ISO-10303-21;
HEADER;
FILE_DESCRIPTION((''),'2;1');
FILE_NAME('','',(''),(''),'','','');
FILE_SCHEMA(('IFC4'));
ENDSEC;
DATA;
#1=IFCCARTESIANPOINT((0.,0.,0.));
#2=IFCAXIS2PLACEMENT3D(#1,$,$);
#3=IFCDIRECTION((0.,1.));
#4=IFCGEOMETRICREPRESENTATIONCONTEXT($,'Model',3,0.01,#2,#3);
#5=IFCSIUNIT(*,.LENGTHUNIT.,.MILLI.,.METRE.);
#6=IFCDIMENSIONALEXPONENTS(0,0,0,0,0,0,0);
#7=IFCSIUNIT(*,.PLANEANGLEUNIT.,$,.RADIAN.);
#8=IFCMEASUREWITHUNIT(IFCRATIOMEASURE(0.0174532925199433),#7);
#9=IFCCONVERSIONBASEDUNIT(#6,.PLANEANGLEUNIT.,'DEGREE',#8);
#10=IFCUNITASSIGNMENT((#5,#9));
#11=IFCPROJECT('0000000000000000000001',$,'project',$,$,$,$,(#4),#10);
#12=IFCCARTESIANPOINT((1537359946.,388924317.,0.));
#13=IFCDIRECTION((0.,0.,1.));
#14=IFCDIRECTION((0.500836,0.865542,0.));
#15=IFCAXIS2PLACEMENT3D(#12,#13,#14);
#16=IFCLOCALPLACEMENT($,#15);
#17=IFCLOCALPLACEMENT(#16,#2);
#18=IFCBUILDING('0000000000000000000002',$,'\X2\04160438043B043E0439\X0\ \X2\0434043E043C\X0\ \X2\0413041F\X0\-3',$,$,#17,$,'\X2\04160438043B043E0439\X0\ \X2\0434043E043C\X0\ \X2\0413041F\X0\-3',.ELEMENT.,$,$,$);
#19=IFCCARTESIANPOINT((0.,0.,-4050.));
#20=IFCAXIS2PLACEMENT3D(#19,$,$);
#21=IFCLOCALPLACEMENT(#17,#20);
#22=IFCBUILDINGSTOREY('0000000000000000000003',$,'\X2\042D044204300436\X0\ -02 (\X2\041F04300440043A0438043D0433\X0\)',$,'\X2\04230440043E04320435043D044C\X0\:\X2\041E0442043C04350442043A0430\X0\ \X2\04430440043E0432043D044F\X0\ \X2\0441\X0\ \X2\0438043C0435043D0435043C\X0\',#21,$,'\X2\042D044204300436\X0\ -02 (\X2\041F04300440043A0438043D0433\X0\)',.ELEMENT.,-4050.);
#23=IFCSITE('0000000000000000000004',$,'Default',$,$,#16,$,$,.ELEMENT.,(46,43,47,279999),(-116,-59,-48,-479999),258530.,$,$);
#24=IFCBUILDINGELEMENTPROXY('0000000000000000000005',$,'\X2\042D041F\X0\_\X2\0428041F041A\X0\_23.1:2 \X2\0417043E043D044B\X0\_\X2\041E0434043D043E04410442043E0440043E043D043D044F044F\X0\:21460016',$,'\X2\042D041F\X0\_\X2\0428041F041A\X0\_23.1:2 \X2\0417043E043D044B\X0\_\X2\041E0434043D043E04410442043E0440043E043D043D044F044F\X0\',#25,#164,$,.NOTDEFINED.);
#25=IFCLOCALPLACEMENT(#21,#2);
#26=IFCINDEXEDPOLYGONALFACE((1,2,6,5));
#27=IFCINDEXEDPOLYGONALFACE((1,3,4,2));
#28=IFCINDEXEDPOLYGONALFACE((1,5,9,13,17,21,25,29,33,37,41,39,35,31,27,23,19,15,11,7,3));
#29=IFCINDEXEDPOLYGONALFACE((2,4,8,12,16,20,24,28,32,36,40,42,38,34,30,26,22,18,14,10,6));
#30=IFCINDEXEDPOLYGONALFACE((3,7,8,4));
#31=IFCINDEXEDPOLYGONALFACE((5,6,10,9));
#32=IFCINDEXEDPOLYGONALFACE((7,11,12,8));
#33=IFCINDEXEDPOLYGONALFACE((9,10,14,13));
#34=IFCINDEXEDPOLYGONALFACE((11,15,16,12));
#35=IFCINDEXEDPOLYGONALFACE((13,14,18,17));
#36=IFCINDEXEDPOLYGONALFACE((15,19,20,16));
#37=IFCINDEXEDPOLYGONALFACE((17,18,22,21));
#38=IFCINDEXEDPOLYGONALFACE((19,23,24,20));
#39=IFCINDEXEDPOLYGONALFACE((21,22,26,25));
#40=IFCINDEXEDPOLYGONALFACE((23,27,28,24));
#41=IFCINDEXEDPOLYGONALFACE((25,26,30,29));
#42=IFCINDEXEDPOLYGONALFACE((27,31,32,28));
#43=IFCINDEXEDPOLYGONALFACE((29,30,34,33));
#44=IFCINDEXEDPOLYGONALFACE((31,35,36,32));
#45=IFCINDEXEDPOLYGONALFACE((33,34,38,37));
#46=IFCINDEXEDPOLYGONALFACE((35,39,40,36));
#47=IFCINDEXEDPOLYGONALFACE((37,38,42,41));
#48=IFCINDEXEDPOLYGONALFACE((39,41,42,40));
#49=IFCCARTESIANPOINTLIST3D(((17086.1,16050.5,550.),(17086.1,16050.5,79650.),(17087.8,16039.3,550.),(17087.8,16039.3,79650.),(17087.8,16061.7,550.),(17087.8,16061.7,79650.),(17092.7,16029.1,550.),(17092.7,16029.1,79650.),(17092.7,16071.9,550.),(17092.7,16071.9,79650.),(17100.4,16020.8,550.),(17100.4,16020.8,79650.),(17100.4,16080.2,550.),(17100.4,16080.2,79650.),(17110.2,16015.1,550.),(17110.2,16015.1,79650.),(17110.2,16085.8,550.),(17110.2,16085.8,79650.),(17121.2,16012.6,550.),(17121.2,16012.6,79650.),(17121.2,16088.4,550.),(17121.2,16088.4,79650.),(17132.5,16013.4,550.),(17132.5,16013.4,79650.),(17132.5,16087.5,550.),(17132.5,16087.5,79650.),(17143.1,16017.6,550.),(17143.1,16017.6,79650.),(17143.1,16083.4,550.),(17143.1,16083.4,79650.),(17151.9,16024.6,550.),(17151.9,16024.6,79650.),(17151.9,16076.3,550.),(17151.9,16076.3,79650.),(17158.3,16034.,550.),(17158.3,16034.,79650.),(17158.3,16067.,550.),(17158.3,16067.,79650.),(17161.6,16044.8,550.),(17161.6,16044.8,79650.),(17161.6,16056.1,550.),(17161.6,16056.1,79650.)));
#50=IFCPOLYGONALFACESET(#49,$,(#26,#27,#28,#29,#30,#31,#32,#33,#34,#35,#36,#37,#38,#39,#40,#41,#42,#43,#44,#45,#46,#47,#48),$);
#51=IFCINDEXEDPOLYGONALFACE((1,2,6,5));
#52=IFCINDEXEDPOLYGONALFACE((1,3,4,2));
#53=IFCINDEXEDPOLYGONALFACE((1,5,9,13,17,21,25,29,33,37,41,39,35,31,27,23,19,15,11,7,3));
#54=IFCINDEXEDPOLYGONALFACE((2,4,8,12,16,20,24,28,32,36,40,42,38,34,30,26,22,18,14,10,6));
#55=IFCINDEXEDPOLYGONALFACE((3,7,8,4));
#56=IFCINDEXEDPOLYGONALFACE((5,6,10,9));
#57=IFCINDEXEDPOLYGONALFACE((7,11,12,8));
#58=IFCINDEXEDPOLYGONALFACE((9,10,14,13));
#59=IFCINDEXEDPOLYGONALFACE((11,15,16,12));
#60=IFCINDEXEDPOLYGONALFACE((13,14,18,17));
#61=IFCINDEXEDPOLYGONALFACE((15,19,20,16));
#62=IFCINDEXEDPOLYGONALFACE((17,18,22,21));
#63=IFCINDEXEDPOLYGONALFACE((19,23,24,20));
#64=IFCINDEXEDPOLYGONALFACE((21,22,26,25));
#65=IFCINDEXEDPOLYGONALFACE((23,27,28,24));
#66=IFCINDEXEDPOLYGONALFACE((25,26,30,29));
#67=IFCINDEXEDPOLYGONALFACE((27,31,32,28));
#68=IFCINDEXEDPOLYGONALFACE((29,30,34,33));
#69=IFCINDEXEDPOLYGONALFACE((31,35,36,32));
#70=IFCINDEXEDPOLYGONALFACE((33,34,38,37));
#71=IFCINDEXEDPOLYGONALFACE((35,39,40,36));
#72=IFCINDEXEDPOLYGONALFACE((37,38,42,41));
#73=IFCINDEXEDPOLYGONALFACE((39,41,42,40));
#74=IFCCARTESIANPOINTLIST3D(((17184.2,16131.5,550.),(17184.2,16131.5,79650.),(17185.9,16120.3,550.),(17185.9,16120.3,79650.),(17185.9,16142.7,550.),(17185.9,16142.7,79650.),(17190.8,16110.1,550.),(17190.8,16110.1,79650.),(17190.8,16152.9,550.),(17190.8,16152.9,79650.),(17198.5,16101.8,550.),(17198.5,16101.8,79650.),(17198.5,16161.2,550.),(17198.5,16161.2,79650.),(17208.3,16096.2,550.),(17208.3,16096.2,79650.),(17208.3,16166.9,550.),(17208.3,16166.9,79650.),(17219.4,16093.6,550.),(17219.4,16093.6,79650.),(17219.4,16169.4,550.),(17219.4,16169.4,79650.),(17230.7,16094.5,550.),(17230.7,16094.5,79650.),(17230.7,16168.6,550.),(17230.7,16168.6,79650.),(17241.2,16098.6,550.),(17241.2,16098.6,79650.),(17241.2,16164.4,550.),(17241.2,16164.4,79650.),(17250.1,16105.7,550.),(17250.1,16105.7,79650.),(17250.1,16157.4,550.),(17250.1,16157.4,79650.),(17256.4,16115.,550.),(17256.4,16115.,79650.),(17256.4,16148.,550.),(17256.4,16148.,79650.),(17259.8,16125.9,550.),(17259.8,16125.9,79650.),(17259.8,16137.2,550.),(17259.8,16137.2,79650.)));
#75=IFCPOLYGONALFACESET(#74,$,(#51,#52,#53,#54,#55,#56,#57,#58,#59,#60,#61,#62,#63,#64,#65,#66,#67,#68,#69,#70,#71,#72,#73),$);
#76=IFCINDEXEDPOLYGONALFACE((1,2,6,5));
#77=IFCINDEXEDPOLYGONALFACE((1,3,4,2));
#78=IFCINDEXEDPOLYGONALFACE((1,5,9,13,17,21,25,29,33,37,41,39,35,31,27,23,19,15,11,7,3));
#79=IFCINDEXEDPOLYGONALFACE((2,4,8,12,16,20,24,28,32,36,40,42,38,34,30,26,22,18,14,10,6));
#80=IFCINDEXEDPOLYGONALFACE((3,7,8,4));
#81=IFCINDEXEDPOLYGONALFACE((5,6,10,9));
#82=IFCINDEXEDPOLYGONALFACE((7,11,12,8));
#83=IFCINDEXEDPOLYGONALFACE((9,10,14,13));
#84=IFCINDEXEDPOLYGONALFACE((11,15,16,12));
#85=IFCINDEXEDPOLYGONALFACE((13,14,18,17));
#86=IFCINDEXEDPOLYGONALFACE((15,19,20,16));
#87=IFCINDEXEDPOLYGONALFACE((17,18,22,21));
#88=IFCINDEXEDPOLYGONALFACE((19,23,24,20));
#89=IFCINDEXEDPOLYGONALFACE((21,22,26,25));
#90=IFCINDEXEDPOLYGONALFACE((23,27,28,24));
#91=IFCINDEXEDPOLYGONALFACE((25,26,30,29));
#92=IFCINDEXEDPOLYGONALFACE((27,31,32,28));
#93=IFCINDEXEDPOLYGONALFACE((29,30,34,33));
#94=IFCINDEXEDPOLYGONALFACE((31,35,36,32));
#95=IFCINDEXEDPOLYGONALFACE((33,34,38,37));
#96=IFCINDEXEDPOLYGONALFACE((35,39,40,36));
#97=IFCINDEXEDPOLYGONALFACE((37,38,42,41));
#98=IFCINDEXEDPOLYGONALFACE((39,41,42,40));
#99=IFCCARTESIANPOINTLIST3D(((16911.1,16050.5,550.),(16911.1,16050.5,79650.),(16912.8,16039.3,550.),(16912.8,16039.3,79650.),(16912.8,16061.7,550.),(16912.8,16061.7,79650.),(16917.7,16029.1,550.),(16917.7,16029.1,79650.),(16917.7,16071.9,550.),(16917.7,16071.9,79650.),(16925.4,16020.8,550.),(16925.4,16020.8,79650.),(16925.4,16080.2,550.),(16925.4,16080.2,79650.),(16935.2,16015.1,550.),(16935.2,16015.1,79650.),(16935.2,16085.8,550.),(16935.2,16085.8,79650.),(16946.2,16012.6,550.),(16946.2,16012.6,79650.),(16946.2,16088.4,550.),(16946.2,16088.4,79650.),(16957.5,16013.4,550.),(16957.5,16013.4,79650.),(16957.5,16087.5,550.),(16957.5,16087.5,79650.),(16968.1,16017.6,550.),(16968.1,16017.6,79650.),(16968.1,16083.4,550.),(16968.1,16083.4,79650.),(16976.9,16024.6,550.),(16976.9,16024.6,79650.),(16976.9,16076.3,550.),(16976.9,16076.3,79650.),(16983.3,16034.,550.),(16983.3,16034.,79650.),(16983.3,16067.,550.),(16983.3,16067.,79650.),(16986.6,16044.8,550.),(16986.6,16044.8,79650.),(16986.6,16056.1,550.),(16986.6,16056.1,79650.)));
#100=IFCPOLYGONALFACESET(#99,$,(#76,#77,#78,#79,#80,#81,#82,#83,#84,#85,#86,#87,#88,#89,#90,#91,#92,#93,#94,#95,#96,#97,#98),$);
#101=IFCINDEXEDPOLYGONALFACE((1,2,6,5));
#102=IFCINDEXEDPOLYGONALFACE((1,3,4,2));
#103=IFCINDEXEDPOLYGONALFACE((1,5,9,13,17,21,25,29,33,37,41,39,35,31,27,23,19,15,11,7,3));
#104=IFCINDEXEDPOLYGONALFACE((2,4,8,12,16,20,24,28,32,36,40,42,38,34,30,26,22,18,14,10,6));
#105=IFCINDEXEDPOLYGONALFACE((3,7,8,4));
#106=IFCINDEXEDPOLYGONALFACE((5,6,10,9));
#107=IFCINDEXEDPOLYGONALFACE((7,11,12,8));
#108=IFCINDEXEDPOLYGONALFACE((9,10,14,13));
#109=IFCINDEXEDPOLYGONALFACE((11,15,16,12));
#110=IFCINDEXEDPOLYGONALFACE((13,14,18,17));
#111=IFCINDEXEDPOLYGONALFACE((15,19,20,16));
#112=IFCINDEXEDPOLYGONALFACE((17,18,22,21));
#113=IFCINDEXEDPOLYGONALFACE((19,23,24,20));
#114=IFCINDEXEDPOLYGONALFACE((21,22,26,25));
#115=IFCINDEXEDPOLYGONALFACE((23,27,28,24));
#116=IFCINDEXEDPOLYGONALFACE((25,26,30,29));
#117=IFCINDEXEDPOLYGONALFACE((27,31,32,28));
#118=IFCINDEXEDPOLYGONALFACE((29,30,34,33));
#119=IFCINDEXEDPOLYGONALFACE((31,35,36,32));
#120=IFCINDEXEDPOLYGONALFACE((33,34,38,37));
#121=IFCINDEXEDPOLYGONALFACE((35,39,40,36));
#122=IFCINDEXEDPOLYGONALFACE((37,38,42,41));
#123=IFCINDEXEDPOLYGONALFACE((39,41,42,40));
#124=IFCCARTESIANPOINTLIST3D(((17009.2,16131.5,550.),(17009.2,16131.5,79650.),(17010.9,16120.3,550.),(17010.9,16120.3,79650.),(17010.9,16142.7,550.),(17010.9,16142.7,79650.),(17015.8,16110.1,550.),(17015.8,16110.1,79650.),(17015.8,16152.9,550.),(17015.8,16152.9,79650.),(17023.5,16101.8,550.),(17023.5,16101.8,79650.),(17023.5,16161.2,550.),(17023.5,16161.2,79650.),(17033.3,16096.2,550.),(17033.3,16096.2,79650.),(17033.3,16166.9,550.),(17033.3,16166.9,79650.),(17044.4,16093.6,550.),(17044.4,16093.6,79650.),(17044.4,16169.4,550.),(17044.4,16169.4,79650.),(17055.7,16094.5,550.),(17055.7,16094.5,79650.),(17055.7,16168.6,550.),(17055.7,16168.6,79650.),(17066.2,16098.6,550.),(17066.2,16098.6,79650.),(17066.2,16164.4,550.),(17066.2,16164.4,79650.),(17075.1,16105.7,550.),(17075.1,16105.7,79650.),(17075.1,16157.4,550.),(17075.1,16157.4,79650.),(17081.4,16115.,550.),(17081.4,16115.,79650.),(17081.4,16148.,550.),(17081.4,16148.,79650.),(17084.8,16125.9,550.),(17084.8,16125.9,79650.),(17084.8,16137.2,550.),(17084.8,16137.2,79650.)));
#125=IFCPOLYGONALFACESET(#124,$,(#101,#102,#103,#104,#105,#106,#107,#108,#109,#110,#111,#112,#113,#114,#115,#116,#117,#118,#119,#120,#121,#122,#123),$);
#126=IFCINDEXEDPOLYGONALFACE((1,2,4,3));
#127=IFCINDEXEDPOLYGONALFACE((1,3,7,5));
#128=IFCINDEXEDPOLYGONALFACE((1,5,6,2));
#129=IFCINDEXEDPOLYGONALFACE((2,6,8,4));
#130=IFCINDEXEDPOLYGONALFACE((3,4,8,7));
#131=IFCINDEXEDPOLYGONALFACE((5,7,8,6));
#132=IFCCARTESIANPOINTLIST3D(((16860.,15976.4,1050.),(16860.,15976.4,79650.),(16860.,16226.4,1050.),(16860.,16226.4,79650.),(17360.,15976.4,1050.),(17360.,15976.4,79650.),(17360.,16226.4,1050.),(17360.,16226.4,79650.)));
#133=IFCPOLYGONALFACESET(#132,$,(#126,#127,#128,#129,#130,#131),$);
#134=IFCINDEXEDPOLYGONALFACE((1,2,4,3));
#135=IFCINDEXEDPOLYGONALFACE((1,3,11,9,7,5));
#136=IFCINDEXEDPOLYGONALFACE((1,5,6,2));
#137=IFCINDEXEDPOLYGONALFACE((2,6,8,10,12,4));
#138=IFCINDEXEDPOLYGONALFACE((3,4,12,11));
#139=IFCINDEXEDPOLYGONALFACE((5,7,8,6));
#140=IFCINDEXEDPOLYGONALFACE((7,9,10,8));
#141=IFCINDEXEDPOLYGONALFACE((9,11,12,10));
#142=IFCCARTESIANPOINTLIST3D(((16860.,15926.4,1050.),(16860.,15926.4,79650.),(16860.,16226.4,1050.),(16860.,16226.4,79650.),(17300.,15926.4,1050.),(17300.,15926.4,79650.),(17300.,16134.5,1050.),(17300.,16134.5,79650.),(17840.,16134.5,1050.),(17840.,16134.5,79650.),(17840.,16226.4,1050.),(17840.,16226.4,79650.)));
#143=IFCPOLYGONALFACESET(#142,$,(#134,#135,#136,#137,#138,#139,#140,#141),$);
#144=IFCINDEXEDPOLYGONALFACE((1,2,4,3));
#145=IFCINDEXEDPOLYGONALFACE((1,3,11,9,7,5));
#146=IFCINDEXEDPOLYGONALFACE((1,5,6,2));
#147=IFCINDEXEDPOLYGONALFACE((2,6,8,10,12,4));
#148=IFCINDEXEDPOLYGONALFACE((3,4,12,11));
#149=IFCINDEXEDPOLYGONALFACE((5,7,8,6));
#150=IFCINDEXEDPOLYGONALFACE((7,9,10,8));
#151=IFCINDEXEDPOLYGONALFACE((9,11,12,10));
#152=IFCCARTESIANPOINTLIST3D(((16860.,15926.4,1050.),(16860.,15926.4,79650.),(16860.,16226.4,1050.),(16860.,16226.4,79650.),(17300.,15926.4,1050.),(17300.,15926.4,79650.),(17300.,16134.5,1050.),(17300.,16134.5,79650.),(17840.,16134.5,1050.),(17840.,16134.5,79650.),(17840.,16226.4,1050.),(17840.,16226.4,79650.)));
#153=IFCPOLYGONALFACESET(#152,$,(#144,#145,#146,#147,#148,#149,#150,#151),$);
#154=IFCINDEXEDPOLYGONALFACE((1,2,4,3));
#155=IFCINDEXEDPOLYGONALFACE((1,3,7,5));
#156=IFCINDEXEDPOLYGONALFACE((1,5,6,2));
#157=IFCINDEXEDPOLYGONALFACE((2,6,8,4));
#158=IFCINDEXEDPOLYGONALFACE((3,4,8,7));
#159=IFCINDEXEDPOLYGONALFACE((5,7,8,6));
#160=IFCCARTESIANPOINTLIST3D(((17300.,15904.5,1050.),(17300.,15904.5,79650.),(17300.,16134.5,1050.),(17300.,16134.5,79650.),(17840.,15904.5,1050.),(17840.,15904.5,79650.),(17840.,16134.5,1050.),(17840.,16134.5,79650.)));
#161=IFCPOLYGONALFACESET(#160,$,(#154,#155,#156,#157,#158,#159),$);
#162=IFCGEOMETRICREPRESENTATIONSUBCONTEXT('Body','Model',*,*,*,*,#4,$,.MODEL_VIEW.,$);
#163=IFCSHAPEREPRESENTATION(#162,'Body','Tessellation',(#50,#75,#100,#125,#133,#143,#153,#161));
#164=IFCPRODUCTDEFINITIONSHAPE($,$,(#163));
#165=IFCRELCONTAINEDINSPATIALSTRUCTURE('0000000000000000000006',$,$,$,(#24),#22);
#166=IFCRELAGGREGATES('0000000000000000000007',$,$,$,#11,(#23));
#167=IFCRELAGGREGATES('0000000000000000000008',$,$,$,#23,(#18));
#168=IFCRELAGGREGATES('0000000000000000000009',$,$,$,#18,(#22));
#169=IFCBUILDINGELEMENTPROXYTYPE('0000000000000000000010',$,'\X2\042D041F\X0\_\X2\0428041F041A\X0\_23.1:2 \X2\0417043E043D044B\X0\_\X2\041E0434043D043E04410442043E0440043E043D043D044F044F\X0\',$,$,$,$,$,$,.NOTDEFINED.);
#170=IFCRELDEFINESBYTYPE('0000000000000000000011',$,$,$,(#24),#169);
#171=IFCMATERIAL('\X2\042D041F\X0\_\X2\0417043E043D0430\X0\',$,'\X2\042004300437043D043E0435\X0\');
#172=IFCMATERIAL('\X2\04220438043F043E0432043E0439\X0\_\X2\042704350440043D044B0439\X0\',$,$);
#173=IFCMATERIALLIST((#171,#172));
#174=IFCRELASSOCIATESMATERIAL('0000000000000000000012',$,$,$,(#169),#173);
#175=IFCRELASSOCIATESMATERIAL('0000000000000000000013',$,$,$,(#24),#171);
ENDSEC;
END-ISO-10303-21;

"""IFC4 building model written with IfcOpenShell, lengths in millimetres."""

from ifc_helpers import new_model, entity, si_unit, converted_unit, direction, frame, frame_2d, origin, origin_2d_with_axis, place, context, subcontext, project, spatial, polyline, rectangle, circle, outline, extrude, source, transform, mapped, material, material_list, type_object, type_shapes, element, save


model = new_model("IFC4")

# Units and contexts
model_context = context("Model", 3, precision=0.01, world=origin(), true_north=direction((0.0, 1.0)))
body_context = subcontext(model_context, "Body", "Model", "MODEL_VIEW")
ifc_project = project(units=[si_unit("LENGTHUNIT", "METRE", prefix="MILLI"), converted_unit("PLANEANGLEUNIT", "DEGREE", entity("IfcRatioMeasure", 0.0174532925199433), si_unit("PLANEANGLEUNIT", "RADIAN"), dimensions=[0, 0, 0, 0, 0, 0, 0])], contexts=[model_context])

# Site, building, storey
site_placement = place(None, frame((1537359946.0, 388924317.0, 0.0), z_axis=(0.0, 0.0, 1.0), x_axis=(0.500836, 0.865542, 0.0)))
site = spatial("IfcSite", under=ifc_project, at=site_placement, Name="Default", CompositionType="ELEMENT", RefLatitude=(46, 43, 47, 279999), RefLongitude=(-116, -59, -48, -479999), RefElevation=258530.0)
building_placement = place(site_placement, origin())
building = spatial("IfcBuilding", under=site, at=building_placement, Name="Жилой дом ГП-3", LongName="Жилой дом ГП-3", CompositionType="ELEMENT")
storey_placement = place(building_placement, frame((0.0, 0.0, -4050.0)))
storey = spatial("IfcBuildingStorey", under=building, at=storey_placement, Name="Этаж -02 (Паркинг)", ObjectType="Уровень:Отметка уровня с именем", LongName="Этаж -02 (Паркинг)", CompositionType="ELEMENT", Elevation=-4050.0)

# Building element proxy
ifc_material_1 = material(Name="Типовой_Черный")
ifc_material_2 = material(Name="ЭП_Зона", Category="Разное")
ifc_material_list_1 = material_list([ifc_material_2, ifc_material_1])
building_element_proxy_type_1 = type_object("IfcBuildingElementProxyType", Name="ЭП_ШПК_23.1:2 Зоны_Односторонняя", PredefinedType="NOTDEFINED", material=ifc_material_list_1)
shared_shape_1 = source(origin(), body_context, "Body", "SweptSolid", [
    extrude(circle(Radius=38.0, at=frame_2d((0.0, 0.0), x_axis=(1.0, 0.0))), frame((264.1, -176.0, -3500.0), z_axis=(0.0, 0.0, 1.0), x_axis=(-1.0, 0.0, 0.0)), (0.0, 0.0, 1.0), 79100.0),
    extrude(circle(Radius=38.0, at=frame_2d((0.0, 0.0), x_axis=(1.0, 0.0))), frame((362.2, -94.9, -3500.0), z_axis=(0.0, 0.0, 1.0), x_axis=(-1.0, 0.0, 0.0)), (0.0, 0.0, 1.0), 79100.0),
    extrude(circle(Radius=38.0, at=frame_2d((0.0, 0.0), x_axis=(1.0, 0.0))), frame((89.1, -176.0, -3500.0), z_axis=(0.0, 0.0, 1.0), x_axis=(-1.0, 0.0, 0.0)), (0.0, 0.0, 1.0), 79100.0),
    extrude(circle(Radius=38.0, at=frame_2d((0.0, 0.0), x_axis=(1.0, 0.0))), frame((187.2, -94.9, -3500.0), z_axis=(0.0, 0.0, 1.0), x_axis=(-1.0, 0.0, 0.0)), (0.0, 0.0, 1.0), 79100.0),
    extrude(rectangle(XDim=500.0, YDim=250.0, at=origin_2d_with_axis()), frame((250.0, -125.0, -3000.0), z_axis=(0.0, 0.0, 1.0), x_axis=(-1.0, 0.0, 0.0)), (0.0, 0.0, 1.0), 78600.0),
    extrude(outline(polyline([(-506.7, -130.6), (473.3, -130.6), (473.3, 169.4), (33.3, 169.4), (33.3, -38.7), (-506.7, -38.7), (-506.7, -130.6)])), frame((473.3, -130.6, -3000.0), z_axis=(0.0, 0.0, 1.0), x_axis=(-1.0, 0.0, 0.0)), (0.0, 0.0, 1.0), 78600.0),
    extrude(outline(polyline([(-506.7, -130.6), (473.3, -130.6), (473.3, 169.4), (33.3, 169.4), (33.3, -38.7), (-506.7, -38.7), (-506.7, -130.6)])), frame((473.3, -130.6, -3000.0), z_axis=(0.0, 0.0, 1.0), x_axis=(-1.0, 0.0, 0.0)), (0.0, 0.0, 1.0), 78600.0),
    extrude(rectangle(XDim=230.0, YDim=540.0, at=frame_2d((0.0, 0.0), x_axis=(1.0, 0.0))), frame((710.0, -206.9, -3000.0), z_axis=(0.0, 0.0, 1.0), x_axis=(0.0, 1.0, 0.0)), (0.0, 0.0, 1.0), 78600.0),
])
type_shapes(building_element_proxy_type_1, [shared_shape_1])
proxy_1_placement = place(storey_placement, frame((16860.0, 16226.4, 4050.0)))
element("IfcBuildingElementProxy", 1, at=proxy_1_placement, inside=storey, type_object=building_element_proxy_type_1, material=ifc_material_2, Name="ЭП_ШПК_23.1:2 Зоны_Односторонняя:21460016", ObjectType="ЭП_ШПК_23.1:2 Зоны_Односторонняя", PredefinedType="NOTDEFINED", context=body_context, shape_type="MappedRepresentation", body=[
    mapped(shared_shape_1, transform((0.0, 0.0, 0.0), scale=1.0)),
])

save(model, "model.ifc")
